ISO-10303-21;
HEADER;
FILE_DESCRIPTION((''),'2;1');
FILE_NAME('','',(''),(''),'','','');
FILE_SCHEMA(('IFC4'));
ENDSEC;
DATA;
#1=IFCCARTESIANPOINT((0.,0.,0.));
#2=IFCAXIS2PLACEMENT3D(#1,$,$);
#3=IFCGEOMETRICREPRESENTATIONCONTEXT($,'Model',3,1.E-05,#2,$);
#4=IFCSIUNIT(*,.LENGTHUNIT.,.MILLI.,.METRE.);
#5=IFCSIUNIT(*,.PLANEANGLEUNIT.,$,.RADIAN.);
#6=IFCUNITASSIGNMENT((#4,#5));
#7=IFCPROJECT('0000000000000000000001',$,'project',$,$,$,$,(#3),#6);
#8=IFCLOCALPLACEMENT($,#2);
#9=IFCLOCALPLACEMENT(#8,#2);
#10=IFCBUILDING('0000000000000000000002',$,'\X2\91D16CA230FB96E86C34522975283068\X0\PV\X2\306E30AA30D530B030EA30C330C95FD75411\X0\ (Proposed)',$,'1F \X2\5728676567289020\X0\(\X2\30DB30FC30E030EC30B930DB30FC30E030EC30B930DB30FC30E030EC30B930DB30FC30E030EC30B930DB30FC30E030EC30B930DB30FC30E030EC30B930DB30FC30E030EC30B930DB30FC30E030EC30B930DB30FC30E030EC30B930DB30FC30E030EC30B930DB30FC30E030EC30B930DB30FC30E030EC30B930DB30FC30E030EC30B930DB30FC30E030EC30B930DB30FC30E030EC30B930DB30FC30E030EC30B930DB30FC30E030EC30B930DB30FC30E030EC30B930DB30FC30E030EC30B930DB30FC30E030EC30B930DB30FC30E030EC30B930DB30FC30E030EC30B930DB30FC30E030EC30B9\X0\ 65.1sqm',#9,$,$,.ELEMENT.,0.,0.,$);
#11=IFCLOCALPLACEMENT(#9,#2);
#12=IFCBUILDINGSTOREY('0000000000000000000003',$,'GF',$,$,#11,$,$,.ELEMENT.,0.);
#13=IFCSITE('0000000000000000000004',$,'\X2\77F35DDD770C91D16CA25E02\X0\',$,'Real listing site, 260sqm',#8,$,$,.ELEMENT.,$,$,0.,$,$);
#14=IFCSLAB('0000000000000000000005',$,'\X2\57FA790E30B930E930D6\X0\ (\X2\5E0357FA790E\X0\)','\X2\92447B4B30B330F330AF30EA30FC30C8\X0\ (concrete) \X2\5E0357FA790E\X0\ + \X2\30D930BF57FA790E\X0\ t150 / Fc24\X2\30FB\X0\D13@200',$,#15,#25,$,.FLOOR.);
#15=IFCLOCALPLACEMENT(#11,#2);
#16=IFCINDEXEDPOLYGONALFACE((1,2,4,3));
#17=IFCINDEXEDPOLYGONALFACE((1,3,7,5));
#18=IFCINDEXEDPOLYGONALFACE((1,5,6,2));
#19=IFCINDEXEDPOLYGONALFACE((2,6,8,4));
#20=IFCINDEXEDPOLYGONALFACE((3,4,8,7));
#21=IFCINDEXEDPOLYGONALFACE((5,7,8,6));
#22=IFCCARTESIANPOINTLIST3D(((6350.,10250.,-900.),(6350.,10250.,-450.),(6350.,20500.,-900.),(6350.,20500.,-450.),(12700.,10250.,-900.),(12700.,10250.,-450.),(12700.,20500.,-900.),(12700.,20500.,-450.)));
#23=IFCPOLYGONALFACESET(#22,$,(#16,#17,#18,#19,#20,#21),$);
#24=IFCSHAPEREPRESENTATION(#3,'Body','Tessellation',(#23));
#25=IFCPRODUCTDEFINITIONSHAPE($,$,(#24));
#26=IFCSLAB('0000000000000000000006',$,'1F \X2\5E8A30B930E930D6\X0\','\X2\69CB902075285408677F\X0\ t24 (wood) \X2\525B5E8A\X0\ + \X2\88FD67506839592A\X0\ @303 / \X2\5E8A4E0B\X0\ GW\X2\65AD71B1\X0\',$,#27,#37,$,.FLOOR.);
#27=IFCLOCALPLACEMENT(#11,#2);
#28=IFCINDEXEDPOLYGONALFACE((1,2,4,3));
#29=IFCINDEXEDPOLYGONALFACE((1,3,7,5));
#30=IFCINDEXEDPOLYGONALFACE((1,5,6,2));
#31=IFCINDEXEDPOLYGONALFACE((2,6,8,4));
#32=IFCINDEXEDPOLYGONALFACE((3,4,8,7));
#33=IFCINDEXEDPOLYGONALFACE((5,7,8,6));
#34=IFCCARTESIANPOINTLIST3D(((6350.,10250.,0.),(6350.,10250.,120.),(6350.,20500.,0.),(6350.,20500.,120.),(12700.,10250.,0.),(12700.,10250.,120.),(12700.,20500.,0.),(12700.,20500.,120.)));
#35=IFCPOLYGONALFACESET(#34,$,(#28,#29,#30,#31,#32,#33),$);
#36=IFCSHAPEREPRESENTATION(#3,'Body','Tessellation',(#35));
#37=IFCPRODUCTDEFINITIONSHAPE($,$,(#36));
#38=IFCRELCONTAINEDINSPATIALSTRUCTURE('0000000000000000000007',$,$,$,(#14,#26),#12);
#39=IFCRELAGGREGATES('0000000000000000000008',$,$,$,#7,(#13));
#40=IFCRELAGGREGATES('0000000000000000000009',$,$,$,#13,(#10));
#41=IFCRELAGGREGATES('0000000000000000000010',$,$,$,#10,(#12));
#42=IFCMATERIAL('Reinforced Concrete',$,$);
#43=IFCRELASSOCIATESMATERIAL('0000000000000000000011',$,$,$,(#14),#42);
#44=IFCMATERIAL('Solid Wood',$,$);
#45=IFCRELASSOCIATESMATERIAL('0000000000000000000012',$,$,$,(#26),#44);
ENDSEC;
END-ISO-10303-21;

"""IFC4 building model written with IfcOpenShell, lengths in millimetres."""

from ifc_helpers import new_model, si_unit, frame, frame_2d, origin, place, context, project, spatial, rectangle, extrude, material, element, save


model = new_model("IFC4")

# Units and contexts
model_context = context("Model", 3, precision=1e-05, world=origin())
ifc_project = project(units=[si_unit("LENGTHUNIT", "METRE", prefix="MILLI"), si_unit("PLANEANGLEUNIT", "RADIAN")], contexts=[model_context])

# Site, building, storey
site_placement = place(None, origin())
site = spatial("IfcSite", under=ifc_project, at=site_placement, Name="石川県金沢市", ObjectType="Real listing site, 260sqm", CompositionType="ELEMENT", RefElevation=0.0)
building_placement = place(site_placement, origin())
building = spatial("IfcBuilding", under=site, at=building_placement, Name="金沢・雨水利用とPVのオフグリッド志向 (Proposed)", ObjectType="1F 在来木造(ホームレスホームレスホームレスホームレスホームレスホームレスホームレスホームレスホームレスホームレスホームレスホームレスホームレスホームレスホームレスホームレスホームレスホームレスホームレスホームレスホームレスホームレスホームレス 65.1sqm", CompositionType="ELEMENT", ElevationOfRefHeight=0.0, ElevationOfTerrain=0.0)
storey_placement = place(building_placement, origin())
storey = spatial("IfcBuildingStorey", under=building, at=storey_placement, Name="GF", CompositionType="ELEMENT", Elevation=0.0)

# Shared definitions
ifc_material_1 = material(Name="Solid Wood")

# Slabs
ifc_material_2 = material(Name="Reinforced Concrete")
slab_1_placement = place(storey_placement, frame((3175.0, 5125.0, -450.0)))
element("IfcSlab", 1, at=slab_1_placement, inside=storey, material=ifc_material_2, Name="基礎スラブ (布基礎)", Description="鉄筋コンクリート (concrete) 布基礎 + ベタ基礎 t150 / Fc24・D13@200", PredefinedType="FLOOR", context=model_context, shape_type="SweptSolid", body=[
    extrude(rectangle(XDim=6350.0, YDim=10250.0, at=frame_2d((3175.0, 5125.0))), frame((3175.0, 5125.0, -450.0)), (0.0, 0.0, 1.0), 450.0),
])
slab_2_placement = place(storey_placement, frame((3175.0, 5125.0, 0.0)))
element("IfcSlab", 2, at=slab_2_placement, inside=storey, material=ifc_material_1, Name="1F 床スラブ", Description="構造用合板 t24 (wood) 剛床 + 製材根太 @303 / 床下 GW断熱", PredefinedType="FLOOR", context=model_context, shape_type="SweptSolid", body=[
    extrude(rectangle(XDim=6350.0, YDim=10250.0, at=frame_2d((3175.0, 5125.0))), frame((3175.0, 5125.0, 0.0)), (0.0, 0.0, 1.0), 120.0),
])

save(model, "model.ifc")
